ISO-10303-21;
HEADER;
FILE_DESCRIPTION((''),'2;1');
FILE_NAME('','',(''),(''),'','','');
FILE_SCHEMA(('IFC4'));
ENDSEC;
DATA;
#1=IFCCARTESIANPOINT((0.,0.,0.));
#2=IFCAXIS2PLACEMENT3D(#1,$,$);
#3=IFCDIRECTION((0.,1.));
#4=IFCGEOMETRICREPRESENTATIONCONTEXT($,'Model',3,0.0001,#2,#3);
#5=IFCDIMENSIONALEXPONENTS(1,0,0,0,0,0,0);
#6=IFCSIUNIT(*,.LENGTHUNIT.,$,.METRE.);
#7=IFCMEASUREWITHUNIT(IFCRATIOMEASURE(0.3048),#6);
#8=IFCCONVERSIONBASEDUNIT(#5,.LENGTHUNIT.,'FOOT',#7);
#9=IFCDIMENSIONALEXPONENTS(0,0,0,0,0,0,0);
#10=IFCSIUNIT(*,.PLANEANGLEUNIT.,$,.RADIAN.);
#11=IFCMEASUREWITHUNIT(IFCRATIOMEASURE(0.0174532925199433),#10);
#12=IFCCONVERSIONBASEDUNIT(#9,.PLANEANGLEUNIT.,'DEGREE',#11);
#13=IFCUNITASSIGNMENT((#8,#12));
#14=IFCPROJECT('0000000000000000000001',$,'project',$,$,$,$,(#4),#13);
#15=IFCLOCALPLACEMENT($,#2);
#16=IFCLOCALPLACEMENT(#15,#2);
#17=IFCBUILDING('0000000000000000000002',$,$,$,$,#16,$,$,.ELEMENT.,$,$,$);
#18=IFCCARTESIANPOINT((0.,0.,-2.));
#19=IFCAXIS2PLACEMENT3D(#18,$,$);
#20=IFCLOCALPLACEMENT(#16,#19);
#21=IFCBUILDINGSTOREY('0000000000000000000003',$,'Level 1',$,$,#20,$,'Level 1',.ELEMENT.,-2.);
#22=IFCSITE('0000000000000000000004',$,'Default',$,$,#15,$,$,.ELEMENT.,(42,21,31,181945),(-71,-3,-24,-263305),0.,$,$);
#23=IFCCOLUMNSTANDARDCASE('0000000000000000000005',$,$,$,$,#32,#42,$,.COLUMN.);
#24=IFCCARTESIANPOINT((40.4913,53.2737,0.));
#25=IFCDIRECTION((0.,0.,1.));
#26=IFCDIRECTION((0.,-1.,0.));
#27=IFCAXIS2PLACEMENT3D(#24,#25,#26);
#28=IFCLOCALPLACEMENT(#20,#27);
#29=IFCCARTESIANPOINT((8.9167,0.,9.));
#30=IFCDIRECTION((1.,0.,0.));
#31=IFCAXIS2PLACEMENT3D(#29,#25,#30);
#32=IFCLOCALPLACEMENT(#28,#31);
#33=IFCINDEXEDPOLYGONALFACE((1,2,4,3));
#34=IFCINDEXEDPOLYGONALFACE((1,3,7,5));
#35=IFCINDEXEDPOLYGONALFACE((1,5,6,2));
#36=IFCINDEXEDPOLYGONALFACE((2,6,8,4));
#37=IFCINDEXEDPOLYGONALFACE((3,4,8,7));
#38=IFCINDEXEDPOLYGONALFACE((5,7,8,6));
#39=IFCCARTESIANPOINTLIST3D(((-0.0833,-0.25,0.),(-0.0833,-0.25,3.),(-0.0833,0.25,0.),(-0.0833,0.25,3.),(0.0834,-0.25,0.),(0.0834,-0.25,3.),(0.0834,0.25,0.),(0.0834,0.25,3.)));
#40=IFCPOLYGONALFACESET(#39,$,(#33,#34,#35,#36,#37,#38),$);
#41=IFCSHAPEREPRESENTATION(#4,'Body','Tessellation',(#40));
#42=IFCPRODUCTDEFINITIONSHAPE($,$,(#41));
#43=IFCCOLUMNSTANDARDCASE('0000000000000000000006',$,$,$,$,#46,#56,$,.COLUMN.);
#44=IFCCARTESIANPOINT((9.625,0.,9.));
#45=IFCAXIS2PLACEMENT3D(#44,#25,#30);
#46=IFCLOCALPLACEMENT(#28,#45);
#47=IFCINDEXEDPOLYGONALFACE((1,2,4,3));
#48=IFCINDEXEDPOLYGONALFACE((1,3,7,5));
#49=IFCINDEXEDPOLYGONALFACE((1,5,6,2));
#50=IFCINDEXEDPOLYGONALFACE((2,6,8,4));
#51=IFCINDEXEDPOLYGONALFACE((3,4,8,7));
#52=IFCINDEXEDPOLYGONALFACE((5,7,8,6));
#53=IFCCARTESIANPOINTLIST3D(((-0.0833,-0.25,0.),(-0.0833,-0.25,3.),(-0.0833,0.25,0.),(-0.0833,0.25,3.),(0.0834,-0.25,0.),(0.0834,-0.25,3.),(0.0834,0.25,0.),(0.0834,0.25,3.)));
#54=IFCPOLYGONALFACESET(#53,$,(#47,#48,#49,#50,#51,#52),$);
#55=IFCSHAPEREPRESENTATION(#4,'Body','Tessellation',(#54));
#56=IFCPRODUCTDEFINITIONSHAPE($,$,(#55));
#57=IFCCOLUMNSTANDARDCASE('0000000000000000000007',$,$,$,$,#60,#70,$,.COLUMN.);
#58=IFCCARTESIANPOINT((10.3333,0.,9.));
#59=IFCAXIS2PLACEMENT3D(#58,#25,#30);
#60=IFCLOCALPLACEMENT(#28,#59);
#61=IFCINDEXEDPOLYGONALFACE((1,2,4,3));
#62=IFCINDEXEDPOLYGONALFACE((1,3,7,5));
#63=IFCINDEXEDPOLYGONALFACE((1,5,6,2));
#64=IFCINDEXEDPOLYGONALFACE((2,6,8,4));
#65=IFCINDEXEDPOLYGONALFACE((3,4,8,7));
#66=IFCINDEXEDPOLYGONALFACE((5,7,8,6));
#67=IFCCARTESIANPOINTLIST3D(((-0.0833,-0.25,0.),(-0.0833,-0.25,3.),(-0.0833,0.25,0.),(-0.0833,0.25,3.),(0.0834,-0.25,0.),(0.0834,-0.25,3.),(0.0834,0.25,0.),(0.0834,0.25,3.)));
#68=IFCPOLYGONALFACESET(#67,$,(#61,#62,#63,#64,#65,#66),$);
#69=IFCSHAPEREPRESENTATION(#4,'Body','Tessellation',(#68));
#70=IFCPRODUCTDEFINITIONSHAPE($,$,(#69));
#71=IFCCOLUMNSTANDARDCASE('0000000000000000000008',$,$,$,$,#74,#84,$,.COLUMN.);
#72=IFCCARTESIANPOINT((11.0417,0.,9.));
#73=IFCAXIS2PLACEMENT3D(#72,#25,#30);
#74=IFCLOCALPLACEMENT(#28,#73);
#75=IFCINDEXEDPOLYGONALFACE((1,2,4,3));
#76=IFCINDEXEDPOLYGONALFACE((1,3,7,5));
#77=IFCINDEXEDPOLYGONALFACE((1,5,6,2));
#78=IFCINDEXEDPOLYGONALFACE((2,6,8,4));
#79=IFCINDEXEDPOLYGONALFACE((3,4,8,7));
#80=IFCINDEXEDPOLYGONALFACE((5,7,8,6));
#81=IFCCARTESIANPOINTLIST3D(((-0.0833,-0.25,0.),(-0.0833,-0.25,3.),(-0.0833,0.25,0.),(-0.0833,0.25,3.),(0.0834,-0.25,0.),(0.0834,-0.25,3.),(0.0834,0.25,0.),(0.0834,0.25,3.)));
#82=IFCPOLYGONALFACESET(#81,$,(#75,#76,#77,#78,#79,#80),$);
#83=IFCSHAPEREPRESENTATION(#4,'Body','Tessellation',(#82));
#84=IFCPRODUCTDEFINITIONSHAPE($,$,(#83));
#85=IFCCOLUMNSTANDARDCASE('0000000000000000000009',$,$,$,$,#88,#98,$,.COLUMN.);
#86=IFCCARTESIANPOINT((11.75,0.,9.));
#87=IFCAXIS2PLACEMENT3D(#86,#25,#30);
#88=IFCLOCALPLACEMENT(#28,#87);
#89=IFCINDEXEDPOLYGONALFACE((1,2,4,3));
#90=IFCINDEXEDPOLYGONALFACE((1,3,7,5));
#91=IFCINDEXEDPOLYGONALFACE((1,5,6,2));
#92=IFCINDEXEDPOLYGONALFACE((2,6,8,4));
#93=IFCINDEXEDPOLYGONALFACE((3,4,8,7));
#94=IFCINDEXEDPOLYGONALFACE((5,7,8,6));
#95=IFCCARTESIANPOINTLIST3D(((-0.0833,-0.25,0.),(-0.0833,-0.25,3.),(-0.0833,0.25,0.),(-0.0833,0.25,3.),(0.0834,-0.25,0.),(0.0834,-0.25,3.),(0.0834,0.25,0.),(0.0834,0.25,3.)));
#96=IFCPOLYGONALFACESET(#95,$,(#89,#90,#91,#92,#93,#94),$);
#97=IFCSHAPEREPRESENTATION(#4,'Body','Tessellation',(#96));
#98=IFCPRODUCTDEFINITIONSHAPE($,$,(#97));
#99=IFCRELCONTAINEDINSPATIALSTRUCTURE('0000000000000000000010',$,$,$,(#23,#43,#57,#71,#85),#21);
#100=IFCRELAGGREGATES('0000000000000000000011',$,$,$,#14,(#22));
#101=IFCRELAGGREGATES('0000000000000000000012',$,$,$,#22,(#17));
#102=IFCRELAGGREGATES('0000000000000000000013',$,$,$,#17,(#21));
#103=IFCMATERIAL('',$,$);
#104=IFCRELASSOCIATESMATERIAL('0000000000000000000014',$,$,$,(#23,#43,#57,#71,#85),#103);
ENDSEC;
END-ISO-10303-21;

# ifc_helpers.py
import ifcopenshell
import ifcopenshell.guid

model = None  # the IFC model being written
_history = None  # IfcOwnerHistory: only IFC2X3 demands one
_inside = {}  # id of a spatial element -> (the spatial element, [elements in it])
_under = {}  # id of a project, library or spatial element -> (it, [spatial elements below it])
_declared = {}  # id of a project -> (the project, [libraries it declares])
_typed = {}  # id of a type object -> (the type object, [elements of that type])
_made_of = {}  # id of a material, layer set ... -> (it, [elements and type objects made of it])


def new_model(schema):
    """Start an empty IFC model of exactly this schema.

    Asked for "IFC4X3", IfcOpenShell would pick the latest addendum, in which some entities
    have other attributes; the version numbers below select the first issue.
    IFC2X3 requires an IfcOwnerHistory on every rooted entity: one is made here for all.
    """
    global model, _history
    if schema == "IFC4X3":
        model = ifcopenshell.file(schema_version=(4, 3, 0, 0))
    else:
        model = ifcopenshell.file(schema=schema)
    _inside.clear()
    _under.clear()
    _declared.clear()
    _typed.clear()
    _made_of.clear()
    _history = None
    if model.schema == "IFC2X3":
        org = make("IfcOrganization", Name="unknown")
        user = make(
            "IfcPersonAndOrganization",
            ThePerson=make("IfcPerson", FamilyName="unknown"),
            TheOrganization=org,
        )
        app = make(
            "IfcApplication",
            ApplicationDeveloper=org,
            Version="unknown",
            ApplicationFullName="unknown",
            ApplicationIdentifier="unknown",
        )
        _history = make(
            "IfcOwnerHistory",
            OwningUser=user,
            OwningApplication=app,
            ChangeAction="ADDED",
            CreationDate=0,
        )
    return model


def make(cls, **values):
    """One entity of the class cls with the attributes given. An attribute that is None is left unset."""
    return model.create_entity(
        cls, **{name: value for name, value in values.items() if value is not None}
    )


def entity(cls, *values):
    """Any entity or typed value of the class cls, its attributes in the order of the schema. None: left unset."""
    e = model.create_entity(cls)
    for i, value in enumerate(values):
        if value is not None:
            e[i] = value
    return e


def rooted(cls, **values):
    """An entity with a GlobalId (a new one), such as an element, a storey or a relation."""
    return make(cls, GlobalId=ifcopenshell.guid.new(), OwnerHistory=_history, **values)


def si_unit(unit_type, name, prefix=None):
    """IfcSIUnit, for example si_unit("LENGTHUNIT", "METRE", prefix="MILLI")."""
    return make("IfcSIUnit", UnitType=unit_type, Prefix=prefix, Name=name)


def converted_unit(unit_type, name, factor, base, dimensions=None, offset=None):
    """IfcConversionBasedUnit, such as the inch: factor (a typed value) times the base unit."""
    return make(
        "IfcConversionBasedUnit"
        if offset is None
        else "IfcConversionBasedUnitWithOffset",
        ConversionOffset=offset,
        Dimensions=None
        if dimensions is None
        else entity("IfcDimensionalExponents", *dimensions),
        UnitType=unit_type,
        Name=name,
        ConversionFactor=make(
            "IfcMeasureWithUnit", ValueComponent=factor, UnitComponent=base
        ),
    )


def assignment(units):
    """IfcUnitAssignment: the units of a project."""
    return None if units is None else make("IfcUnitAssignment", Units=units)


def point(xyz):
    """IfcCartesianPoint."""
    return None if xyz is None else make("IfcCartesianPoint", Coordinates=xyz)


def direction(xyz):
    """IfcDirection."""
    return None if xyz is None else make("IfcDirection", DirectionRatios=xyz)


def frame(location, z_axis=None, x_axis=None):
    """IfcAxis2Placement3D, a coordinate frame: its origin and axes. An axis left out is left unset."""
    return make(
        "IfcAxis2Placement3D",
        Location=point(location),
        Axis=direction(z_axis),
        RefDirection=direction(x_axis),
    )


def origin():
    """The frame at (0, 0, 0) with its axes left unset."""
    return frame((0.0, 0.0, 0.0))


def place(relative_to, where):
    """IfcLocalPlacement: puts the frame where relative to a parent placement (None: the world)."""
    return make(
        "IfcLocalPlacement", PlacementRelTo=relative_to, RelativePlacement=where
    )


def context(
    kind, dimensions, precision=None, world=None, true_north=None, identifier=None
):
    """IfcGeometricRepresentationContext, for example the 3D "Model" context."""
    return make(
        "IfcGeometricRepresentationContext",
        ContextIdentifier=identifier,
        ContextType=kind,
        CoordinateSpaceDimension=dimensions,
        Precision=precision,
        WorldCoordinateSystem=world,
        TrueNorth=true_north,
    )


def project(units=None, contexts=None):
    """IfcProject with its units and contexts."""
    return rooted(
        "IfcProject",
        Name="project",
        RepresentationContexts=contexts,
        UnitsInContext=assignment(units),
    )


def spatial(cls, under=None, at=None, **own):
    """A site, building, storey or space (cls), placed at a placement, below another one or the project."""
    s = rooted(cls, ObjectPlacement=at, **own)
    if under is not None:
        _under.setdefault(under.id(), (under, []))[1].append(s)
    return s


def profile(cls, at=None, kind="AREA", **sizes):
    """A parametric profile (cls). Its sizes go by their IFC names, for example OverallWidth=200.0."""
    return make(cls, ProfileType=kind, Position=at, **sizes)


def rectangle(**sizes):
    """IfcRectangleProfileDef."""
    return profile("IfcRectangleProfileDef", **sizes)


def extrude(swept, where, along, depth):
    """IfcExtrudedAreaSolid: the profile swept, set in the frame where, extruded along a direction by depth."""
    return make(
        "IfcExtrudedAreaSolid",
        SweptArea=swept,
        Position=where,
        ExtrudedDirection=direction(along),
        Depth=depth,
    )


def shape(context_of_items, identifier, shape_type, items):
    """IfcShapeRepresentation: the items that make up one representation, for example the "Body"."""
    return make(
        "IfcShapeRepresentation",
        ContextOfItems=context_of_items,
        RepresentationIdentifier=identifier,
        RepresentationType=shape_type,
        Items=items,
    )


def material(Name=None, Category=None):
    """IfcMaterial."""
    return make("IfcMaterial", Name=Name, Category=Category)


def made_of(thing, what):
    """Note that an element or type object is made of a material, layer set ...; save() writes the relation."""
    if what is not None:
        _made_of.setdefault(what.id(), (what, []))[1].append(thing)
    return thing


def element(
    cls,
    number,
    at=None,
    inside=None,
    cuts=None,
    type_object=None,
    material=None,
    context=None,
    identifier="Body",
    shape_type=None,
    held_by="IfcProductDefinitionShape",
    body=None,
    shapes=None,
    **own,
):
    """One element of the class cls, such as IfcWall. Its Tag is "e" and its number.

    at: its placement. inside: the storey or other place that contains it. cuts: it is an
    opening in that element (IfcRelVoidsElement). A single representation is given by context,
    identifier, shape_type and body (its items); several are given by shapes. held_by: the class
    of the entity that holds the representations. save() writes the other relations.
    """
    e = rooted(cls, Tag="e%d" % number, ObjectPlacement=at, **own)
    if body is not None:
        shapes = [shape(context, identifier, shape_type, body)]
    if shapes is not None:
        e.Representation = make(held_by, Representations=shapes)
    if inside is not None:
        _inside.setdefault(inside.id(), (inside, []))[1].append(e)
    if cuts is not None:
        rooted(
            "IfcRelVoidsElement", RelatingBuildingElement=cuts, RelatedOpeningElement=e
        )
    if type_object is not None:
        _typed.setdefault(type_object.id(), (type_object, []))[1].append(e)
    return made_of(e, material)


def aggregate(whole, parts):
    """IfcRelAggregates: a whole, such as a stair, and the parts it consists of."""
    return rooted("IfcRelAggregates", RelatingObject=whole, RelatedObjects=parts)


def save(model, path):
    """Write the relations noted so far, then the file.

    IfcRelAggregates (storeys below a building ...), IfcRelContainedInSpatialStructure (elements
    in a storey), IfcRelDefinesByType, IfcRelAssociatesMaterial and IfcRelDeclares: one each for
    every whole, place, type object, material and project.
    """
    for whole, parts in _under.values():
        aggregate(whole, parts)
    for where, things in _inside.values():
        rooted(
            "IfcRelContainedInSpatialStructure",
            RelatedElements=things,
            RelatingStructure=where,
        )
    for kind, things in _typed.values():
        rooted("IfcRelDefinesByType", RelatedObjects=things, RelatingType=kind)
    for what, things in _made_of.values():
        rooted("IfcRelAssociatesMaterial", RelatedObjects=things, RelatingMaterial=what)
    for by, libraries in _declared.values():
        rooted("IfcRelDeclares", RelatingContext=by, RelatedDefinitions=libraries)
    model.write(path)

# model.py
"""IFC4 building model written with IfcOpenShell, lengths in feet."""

from ifc_helpers import new_model, entity, si_unit, converted_unit, direction, frame, origin, place, context, project, spatial, rectangle, extrude, material, element, save


model = new_model("IFC4")

# Units and contexts
model_context = context("Model", 3, precision=0.0001, world=origin(), true_north=direction((0.0, 1.0)))
ifc_project = project(units=[converted_unit("LENGTHUNIT", "FOOT", entity("IfcRatioMeasure", 0.3048), si_unit("LENGTHUNIT", "METRE"), dimensions=[1, 0, 0, 0, 0, 0, 0]), converted_unit("PLANEANGLEUNIT", "DEGREE", entity("IfcRatioMeasure", 0.0174532925199433), si_unit("PLANEANGLEUNIT", "RADIAN"), dimensions=[0, 0, 0, 0, 0, 0, 0])], contexts=[model_context])

# Site, building, storey
site_placement = place(None, origin())
site = spatial("IfcSite", under=ifc_project, at=site_placement, Name="Default", CompositionType="ELEMENT", RefLatitude=(42, 21, 31, 181945), RefLongitude=(-71, -3, -24, -263305), RefElevation=0.0)
building_placement = place(site_placement, origin())
building = spatial("IfcBuilding", under=site, at=building_placement, CompositionType="ELEMENT")
storey_placement = place(building_placement, frame((0.0, 0.0, -2.0)))
storey = spatial("IfcBuildingStorey", under=building, at=storey_placement, Name="Level 1", LongName="Level 1", CompositionType="ELEMENT", Elevation=-2.0)

# Columns
ifc_material_1 = material(Name="")
placement_1 = place(storey_placement, frame((40.4913, 53.2737, 0.0), z_axis=(0.0, 0.0, 1.0), x_axis=(0.0, -1.0, 0.0)))
for number, where, z_axis, x_axis in (
    (1, (8.9167, 0.0, 9.0), (0.0, 0.0, 1.0), (1.0, 0.0, 0.0)),
    (2, (9.625, 0.0, 9.0), (0.0, 0.0, 1.0), (1.0, 0.0, 0.0)),
    (3, (10.3333, 0.0, 9.0), (0.0, 0.0, 1.0), (1.0, 0.0, 0.0)),
    (4, (11.0417, 0.0, 9.0), (0.0, 0.0, 1.0), (1.0, 0.0, 0.0)),
    (5, (11.75, 0.0, 9.0), (0.0, 0.0, 1.0), (1.0, 0.0, 0.0)),
):
    element("IfcColumnStandardCase", number, at=place(placement_1, frame(where, z_axis=z_axis, x_axis=x_axis)), inside=storey, material=ifc_material_1, PredefinedType="COLUMN", context=model_context, shape_type="SweptSolid", body=[
        extrude(rectangle(XDim=0.1667, YDim=0.5), origin(), (0.0, 0.0, 1.0), 3.0),
    ])

save(model, "model.ifc")
